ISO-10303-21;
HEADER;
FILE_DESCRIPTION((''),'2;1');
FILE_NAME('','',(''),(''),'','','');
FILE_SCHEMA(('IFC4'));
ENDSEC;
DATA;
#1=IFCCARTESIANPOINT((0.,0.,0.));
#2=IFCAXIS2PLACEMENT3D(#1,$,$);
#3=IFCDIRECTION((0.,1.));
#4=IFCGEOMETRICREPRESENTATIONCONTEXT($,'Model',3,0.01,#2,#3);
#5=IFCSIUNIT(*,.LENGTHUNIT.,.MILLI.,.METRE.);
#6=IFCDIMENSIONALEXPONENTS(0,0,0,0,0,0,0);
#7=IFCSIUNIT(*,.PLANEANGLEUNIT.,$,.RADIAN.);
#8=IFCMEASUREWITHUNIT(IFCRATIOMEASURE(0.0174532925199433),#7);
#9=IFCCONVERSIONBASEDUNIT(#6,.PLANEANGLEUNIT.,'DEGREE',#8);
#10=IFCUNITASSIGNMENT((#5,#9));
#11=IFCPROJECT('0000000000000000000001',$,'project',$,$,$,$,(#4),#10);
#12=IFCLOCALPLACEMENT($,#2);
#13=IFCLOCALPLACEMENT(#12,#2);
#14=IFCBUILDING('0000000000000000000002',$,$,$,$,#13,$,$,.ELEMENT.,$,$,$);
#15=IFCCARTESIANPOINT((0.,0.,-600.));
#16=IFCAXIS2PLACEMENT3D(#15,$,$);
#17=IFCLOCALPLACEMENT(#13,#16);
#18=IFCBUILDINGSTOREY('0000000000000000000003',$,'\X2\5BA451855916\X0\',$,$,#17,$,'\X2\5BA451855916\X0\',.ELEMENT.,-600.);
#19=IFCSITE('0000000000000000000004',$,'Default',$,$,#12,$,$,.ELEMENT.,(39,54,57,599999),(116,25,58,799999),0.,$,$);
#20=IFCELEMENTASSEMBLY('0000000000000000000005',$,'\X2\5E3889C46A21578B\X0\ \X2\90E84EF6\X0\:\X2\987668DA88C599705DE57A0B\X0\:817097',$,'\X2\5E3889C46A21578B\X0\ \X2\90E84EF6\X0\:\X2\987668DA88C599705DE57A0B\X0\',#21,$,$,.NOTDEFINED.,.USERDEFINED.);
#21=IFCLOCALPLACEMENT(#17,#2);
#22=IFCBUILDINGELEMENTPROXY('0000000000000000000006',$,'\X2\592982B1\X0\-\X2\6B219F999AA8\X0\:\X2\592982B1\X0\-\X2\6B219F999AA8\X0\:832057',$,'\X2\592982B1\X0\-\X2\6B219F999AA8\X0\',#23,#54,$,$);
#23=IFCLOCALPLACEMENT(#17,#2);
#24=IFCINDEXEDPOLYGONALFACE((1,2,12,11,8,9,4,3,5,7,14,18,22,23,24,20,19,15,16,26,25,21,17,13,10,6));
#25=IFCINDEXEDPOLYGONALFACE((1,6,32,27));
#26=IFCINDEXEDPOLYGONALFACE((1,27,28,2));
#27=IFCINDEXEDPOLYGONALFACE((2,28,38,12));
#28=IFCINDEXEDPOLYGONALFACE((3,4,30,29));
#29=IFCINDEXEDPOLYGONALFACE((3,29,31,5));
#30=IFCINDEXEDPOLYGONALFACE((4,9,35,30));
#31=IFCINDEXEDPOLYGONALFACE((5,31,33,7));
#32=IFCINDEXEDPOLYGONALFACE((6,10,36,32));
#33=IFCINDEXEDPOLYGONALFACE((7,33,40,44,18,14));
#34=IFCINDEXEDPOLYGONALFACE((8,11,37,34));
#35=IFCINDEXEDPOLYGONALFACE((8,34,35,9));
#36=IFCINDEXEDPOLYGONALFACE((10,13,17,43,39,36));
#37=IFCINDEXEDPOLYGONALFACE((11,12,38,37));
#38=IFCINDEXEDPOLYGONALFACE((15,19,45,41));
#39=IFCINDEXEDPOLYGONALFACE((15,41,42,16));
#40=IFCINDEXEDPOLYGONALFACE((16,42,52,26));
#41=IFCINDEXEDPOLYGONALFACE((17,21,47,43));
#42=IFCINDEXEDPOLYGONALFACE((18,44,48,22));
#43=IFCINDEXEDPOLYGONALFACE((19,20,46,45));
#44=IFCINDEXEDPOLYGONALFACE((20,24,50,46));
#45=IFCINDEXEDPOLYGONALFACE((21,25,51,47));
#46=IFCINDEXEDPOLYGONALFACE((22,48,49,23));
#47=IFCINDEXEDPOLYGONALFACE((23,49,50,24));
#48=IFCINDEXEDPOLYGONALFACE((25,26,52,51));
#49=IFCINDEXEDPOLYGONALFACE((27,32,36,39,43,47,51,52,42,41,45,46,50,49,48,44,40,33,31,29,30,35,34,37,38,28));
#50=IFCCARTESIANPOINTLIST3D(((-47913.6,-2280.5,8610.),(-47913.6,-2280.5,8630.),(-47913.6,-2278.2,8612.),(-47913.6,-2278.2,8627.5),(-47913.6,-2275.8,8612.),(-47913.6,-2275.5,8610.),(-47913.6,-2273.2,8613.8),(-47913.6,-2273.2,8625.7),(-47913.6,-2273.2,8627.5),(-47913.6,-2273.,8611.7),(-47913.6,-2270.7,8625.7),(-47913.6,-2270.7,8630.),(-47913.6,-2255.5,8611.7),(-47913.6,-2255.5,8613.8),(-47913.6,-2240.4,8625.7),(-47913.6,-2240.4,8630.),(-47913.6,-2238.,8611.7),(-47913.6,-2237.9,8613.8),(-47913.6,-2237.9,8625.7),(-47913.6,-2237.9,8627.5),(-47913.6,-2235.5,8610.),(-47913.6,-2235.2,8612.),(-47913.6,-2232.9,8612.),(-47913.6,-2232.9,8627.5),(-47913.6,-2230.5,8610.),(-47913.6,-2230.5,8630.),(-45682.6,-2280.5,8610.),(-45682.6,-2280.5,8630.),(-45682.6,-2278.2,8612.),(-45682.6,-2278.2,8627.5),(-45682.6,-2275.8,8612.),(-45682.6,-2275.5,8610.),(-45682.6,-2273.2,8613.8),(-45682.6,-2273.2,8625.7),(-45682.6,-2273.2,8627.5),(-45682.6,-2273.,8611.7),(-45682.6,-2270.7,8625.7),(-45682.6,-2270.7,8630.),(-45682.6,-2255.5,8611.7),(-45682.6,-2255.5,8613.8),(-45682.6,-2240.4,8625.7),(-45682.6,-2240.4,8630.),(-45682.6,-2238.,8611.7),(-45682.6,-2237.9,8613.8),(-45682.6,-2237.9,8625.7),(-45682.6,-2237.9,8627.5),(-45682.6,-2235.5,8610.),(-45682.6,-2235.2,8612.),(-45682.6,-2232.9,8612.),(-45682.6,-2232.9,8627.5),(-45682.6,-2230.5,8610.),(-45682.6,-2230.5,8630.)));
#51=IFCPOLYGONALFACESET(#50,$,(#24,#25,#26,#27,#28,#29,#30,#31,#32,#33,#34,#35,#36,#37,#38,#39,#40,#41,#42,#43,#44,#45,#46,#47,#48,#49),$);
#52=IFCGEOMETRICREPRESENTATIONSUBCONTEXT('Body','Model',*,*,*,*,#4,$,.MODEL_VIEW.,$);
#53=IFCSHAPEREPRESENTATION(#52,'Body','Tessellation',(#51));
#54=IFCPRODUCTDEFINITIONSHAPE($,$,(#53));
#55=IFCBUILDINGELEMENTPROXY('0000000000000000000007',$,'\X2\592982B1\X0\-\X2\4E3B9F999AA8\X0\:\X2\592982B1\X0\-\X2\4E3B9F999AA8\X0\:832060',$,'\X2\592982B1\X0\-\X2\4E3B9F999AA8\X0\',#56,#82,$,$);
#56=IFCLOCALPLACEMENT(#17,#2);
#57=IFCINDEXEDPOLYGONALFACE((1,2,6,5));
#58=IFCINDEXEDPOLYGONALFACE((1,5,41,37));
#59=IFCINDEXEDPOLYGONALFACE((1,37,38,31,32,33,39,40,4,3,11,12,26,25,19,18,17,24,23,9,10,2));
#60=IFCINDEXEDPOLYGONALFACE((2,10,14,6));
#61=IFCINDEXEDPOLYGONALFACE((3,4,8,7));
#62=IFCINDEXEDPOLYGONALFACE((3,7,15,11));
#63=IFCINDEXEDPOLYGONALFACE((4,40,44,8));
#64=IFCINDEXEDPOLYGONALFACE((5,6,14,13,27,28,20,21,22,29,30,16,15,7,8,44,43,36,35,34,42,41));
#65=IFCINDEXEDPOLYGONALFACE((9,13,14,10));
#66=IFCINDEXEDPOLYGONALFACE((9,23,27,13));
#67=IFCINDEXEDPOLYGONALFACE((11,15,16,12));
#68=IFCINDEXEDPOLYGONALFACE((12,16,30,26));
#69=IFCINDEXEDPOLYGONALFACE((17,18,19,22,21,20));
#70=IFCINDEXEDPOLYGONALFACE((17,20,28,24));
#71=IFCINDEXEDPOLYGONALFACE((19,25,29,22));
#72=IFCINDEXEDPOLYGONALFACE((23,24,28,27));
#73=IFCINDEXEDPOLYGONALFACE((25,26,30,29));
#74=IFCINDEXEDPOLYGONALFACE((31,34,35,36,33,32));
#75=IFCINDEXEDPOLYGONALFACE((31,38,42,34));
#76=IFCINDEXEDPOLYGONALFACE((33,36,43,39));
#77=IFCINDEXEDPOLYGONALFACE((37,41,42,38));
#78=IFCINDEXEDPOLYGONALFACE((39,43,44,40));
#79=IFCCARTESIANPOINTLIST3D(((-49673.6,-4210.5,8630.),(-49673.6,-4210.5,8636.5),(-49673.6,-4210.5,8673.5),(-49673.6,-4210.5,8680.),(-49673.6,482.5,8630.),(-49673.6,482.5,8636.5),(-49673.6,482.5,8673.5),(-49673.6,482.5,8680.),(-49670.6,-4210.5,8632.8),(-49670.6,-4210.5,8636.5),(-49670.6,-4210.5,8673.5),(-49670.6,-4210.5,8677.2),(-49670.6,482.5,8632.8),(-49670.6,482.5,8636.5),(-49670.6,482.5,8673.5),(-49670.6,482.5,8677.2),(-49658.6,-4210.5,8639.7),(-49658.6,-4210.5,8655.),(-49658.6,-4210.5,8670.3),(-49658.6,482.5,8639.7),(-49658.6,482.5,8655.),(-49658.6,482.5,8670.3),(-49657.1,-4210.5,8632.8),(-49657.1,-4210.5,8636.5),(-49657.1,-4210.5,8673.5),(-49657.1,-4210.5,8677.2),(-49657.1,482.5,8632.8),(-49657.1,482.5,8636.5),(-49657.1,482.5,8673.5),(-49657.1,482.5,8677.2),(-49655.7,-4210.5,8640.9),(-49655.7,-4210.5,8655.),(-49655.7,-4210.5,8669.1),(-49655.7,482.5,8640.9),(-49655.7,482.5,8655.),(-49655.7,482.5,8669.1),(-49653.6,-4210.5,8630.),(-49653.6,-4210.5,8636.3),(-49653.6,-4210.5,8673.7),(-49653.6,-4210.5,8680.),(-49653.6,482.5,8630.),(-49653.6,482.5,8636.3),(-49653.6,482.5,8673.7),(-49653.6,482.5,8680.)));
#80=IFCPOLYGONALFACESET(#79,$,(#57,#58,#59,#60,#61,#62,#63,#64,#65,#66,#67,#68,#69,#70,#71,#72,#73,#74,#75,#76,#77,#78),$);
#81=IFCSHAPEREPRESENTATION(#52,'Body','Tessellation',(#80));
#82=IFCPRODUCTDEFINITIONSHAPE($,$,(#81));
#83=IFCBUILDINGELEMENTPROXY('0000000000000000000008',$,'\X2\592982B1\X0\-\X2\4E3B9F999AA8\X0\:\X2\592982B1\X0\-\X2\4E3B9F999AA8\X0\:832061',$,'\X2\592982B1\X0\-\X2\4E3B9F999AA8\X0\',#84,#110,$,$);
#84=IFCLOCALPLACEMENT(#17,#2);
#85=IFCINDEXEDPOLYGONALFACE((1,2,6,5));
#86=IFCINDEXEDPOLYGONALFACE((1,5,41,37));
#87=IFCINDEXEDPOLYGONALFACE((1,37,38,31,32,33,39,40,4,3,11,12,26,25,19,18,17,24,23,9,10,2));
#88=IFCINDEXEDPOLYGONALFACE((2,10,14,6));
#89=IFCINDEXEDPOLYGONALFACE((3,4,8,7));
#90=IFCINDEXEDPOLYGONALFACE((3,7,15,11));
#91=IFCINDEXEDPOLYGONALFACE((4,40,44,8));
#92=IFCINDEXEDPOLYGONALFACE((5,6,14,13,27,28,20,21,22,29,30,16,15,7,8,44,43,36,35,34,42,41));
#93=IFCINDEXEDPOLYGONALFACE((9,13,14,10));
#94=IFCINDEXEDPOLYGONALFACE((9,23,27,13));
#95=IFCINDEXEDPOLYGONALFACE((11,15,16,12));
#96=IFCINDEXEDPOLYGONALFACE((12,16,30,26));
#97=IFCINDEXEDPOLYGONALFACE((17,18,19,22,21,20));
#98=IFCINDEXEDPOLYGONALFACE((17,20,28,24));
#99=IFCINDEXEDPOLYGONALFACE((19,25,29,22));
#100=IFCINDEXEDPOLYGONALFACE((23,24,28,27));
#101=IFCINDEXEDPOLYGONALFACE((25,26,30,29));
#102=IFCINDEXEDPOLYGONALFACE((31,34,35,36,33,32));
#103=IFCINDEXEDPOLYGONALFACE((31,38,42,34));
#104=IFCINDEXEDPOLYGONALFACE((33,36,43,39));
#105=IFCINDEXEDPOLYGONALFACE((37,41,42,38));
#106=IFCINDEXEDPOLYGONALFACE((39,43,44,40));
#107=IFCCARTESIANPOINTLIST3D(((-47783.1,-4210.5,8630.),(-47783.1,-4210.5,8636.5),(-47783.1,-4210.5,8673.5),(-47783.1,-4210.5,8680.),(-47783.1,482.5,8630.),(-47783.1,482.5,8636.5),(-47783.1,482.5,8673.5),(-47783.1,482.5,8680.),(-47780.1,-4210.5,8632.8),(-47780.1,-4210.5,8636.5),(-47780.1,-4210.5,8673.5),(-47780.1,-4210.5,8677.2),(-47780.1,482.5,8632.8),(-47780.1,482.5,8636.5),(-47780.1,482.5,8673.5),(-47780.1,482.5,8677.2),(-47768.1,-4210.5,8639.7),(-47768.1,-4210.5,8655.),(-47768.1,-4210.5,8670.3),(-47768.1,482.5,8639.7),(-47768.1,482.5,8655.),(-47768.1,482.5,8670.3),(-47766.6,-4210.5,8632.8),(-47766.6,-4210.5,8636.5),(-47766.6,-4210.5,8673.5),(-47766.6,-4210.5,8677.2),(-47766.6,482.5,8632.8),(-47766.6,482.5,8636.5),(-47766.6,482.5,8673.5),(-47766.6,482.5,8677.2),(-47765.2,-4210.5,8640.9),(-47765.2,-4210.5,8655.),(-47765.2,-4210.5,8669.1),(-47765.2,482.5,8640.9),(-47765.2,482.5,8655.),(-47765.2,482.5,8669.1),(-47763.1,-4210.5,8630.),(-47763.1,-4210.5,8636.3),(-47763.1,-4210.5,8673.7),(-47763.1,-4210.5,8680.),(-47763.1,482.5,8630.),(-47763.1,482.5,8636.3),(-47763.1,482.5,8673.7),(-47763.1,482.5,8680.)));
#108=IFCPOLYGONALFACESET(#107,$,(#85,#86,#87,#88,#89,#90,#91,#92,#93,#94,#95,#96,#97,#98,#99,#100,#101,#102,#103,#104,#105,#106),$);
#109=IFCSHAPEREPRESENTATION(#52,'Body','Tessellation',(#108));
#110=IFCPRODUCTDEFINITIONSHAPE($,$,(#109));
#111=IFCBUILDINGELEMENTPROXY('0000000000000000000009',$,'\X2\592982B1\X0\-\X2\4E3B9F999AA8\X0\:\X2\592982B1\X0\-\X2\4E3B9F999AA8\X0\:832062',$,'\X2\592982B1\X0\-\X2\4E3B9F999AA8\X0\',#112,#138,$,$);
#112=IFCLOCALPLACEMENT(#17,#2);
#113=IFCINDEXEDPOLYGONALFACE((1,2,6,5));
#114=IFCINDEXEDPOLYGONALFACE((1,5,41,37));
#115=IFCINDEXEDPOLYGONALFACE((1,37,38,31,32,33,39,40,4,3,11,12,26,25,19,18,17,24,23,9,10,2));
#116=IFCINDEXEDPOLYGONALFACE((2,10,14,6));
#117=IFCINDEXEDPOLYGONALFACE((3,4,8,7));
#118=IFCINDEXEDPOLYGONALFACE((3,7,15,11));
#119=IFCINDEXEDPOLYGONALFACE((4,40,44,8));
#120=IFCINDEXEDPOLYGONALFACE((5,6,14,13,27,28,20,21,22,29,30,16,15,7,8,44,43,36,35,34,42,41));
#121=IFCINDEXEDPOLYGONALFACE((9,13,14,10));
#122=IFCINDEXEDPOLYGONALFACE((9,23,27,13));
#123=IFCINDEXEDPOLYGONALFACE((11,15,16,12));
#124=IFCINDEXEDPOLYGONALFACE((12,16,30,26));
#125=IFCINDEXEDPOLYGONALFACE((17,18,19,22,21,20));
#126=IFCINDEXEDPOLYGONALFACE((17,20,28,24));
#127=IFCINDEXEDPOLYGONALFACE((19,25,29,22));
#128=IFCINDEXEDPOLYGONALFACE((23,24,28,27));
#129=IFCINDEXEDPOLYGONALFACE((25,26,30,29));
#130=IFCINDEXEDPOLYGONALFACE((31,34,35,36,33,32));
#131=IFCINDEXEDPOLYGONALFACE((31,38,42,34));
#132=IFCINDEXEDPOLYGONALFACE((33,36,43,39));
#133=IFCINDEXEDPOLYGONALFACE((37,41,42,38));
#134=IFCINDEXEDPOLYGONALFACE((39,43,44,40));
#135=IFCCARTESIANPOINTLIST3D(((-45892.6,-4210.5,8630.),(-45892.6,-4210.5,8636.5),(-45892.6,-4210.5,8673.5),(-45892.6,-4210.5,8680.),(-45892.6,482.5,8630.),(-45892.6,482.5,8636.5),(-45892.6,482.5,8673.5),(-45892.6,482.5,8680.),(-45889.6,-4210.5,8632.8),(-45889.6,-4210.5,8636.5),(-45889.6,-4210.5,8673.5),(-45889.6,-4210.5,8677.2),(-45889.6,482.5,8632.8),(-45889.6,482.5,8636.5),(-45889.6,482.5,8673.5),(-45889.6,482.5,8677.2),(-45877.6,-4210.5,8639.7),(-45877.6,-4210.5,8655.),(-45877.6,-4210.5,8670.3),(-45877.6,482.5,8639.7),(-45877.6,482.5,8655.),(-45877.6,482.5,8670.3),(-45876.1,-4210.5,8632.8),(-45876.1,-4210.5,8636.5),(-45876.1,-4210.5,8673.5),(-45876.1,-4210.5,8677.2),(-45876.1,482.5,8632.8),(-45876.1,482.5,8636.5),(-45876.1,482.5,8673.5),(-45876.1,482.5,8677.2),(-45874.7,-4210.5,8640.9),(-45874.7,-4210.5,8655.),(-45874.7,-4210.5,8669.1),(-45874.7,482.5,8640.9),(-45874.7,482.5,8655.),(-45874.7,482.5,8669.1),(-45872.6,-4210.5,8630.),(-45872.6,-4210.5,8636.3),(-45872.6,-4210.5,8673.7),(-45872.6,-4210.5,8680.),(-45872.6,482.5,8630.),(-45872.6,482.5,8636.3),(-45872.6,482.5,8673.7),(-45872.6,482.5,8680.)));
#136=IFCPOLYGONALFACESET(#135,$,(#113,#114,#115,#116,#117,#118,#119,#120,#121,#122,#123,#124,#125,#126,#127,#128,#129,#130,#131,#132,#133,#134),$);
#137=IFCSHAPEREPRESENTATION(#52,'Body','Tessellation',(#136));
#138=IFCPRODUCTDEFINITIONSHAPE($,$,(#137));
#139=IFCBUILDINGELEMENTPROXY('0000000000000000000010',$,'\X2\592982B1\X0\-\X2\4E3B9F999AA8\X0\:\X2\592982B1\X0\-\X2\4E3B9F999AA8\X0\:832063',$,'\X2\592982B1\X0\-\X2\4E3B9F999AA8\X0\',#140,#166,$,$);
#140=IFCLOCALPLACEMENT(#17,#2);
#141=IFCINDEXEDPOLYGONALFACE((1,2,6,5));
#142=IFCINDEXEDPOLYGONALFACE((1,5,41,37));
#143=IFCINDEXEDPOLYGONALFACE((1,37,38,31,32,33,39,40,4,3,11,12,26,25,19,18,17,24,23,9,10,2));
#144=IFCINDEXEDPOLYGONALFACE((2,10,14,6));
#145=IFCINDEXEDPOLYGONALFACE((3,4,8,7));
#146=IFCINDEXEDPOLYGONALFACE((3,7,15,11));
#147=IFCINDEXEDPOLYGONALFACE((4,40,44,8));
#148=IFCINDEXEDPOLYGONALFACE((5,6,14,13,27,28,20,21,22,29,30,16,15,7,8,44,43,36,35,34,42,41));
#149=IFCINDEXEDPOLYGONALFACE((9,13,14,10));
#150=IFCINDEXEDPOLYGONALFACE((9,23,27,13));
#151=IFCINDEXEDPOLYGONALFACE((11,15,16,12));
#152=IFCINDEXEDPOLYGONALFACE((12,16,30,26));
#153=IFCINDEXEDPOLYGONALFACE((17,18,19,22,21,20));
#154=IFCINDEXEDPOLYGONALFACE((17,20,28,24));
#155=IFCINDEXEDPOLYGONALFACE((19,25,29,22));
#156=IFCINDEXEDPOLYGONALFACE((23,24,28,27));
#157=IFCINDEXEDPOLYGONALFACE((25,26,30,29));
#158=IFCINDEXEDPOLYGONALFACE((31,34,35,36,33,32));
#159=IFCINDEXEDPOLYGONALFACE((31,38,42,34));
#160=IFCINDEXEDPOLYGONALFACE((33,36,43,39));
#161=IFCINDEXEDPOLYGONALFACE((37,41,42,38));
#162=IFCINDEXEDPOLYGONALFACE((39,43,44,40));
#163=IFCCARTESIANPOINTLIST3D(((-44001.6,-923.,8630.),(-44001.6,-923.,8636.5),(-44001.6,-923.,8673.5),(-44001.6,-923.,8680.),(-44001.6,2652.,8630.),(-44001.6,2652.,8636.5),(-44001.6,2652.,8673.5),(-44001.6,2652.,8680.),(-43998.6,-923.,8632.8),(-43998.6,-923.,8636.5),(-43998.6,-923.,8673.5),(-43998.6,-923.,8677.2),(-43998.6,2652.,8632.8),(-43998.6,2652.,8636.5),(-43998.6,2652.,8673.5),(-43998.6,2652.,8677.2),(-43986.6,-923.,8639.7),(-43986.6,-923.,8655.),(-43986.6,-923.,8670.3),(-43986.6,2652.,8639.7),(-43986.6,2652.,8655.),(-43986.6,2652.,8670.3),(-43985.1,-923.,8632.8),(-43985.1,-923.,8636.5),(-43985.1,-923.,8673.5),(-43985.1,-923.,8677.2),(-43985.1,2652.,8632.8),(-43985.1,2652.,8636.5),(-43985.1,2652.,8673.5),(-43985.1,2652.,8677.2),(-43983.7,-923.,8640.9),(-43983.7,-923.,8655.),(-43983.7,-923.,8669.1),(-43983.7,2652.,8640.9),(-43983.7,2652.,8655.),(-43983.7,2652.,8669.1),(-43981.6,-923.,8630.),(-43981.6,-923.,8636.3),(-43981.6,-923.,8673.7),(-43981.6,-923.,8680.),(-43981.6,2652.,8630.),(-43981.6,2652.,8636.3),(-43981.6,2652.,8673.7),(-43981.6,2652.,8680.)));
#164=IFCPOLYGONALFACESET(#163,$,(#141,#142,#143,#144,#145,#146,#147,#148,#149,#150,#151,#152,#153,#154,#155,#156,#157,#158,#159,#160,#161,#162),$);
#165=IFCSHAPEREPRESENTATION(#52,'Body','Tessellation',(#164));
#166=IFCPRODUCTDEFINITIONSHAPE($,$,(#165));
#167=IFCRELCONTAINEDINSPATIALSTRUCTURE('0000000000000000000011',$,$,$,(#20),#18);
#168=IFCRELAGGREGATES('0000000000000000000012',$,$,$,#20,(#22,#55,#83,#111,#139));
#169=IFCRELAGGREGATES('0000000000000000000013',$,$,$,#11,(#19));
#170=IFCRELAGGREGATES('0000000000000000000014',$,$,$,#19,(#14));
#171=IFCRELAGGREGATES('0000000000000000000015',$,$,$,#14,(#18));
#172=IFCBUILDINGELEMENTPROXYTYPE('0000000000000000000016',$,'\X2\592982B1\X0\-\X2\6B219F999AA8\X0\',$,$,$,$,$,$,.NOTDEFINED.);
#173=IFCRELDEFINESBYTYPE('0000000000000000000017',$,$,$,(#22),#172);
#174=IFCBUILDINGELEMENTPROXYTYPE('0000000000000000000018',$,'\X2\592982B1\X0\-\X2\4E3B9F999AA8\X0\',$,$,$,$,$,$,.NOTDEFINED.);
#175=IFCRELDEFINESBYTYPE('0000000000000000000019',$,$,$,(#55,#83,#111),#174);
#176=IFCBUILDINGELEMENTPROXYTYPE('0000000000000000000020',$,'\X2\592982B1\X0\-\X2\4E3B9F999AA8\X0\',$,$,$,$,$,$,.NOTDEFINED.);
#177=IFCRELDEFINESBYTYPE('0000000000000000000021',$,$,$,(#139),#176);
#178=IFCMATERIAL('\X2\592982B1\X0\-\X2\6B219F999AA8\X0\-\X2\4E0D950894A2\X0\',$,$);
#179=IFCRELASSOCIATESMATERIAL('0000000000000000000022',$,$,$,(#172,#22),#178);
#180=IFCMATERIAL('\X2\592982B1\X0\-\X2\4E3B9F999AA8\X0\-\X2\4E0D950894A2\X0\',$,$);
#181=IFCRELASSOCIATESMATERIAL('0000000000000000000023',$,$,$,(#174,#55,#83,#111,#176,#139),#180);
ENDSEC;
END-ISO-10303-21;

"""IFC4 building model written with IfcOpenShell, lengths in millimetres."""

from ifc_helpers import new_model, entity, si_unit, converted_unit, direction, frame, origin, place, context, subcontext, project, spatial, polyline, outline, extrude, source, transform, mapped, material, type_object, type_shapes, element, aggregate, save


model = new_model("IFC4")

# Units and contexts
model_context = context("Model", 3, precision=0.01, world=origin(), true_north=direction((0.0, 1.0)))
body_context = subcontext(model_context, "Body", "Model", "MODEL_VIEW")
ifc_project = project(units=[si_unit("LENGTHUNIT", "METRE", prefix="MILLI"), converted_unit("PLANEANGLEUNIT", "DEGREE", entity("IfcRatioMeasure", 0.0174532925199433), si_unit("PLANEANGLEUNIT", "RADIAN"), dimensions=[0, 0, 0, 0, 0, 0, 0])], contexts=[model_context])

# Site, building, storey
site_placement = place(None, origin())
site = spatial("IfcSite", under=ifc_project, at=site_placement, Name="Default", CompositionType="ELEMENT", RefLatitude=(39, 54, 57, 599999), RefLongitude=(116, 25, 58, 799999), RefElevation=0.0)
building_placement = place(site_placement, origin())
building = spatial("IfcBuilding", under=site, at=building_placement, CompositionType="ELEMENT")
storey_placement = place(building_placement, frame((0.0, 0.0, -600.0)))
storey = spatial("IfcBuildingStorey", under=building, at=storey_placement, Name="室内外", LongName="室内外", CompositionType="ELEMENT", Elevation=-600.0)

# Element assembly, building element proxies
assembly_1_placement = place(storey_placement, origin())
assembly_1 = element("IfcElementAssembly", 1, at=assembly_1_placement, inside=storey, Name="常规模型 部件:顶棚装饰工程:817097", ObjectType="常规模型 部件:顶棚装饰工程", AssemblyPlace="NOTDEFINED", PredefinedType="USERDEFINED")
ifc_material_1 = material(Name="天花-次龙骨-不锈钢")
building_element_proxy_type_1 = type_object("IfcBuildingElementProxyType", Name="天花-次龙骨", PredefinedType="NOTDEFINED", material=ifc_material_1)
shared_shape_1 = source(origin(), body_context, "Body", "SweptSolid", [
    extrude(outline(polyline([(-25.0, -9.1), (-20.0, -9.1), (-17.5, -7.4), (0.0, -7.4), (17.5, -7.4), (20.0, -9.1), (25.0, -9.1), (25.0, 10.9), (15.1, 10.9), (15.1, 6.6), (17.6, 6.6), (17.6, 8.4), (22.6, 8.4), (22.6, -7.1), (20.3, -7.1), (17.6, -5.3), (0.0, -5.3), (-17.6, -5.3), (-20.3, -7.1), (-22.6, -7.1), (-22.6, 8.4), (-17.6, 8.4), (-17.6, 6.6), (-15.1, 6.6), (-15.1, 10.9), (-25.0, 10.9), (-25.0, -9.1)])), frame((0.0, 0.0, -0.9), z_axis=(1.0, 0.0, 0.0), x_axis=(0.0, 1.0, 0.0)), (0.0, 0.0, 1.0), 2231.0),
])
type_shapes(building_element_proxy_type_1, [shared_shape_1])
proxy_1_placement = place(assembly_1_placement, frame((-47913.6, -2255.5, 8620.0)))
proxy_1 = element("IfcBuildingElementProxy", 2, at=proxy_1_placement, type_object=building_element_proxy_type_1, material=ifc_material_1, Name="天花-次龙骨:天花-次龙骨:832057", ObjectType="天花-次龙骨", context=body_context, shape_type="MappedRepresentation", body=[
    mapped(shared_shape_1, transform((0.0, 0.0, 0.0), scale=1.0)),
])
ifc_material_2 = material(Name="天花-主龙骨-不锈钢")
building_element_proxy_type_2 = type_object("IfcBuildingElementProxyType", Name="天花-主龙骨", PredefinedType="NOTDEFINED", material=ifc_material_2)
shared_shape_2 = source(origin(), body_context, "Body", "SweptSolid", [
    extrude(outline(polyline([(-25.0, -11.7), (-18.5, -11.7), (-18.5, -8.7), (-22.2, -8.7), (-22.2, 4.8), (-18.5, 4.8), (-15.3, 3.3), (0.0, 3.3), (15.3, 3.3), (18.5, 4.8), (22.2, 4.8), (22.2, -8.7), (18.5, -8.7), (18.5, -11.7), (25.0, -11.7), (25.0, 8.3), (18.7, 8.3), (14.1, 6.2), (0.0, 6.2), (-14.1, 6.2), (-18.7, 8.3), (-25.0, 8.3), (-25.0, -11.7)])), frame((0.0, 1.7, 0.0), z_axis=(1.0, 0.0, 0.0), x_axis=(0.0, 0.0, -1.0)), (0.0, 0.0, 1.0), 4693.0),
])
type_shapes(building_element_proxy_type_2, [shared_shape_2])
proxy_2_placement = place(assembly_1_placement, frame((-49663.6, 482.5, 8655.0), z_axis=(0.0, 0.0, 1.0), x_axis=(0.0, -1.0, 0.0)))
proxy_2 = element("IfcBuildingElementProxy", 3, at=proxy_2_placement, type_object=building_element_proxy_type_2, material=ifc_material_2, Name="天花-主龙骨:天花-主龙骨:832060", ObjectType="天花-主龙骨", context=body_context, shape_type="MappedRepresentation", body=[
    mapped(shared_shape_2, transform((0.0, 0.0, 0.0), scale=1.0)),
])
proxy_3_placement = place(assembly_1_placement, frame((-47773.1, 482.5, 8655.0), z_axis=(0.0, 0.0, 1.0), x_axis=(0.0, -1.0, 0.0)))
proxy_3 = element("IfcBuildingElementProxy", 4, at=proxy_3_placement, type_object=building_element_proxy_type_2, material=ifc_material_2, Name="天花-主龙骨:天花-主龙骨:832061", ObjectType="天花-主龙骨", context=body_context, shape_type="MappedRepresentation", body=[
    mapped(shared_shape_2, transform((0.0, 0.0, 0.0), scale=1.0)),
])
proxy_4_placement = place(assembly_1_placement, frame((-45882.6, 482.5, 8655.0), z_axis=(0.0, 0.0, 1.0), x_axis=(0.0, -1.0, 0.0)))
proxy_4 = element("IfcBuildingElementProxy", 5, at=proxy_4_placement, type_object=building_element_proxy_type_2, material=ifc_material_2, Name="天花-主龙骨:天花-主龙骨:832062", ObjectType="天花-主龙骨", context=body_context, shape_type="MappedRepresentation", body=[
    mapped(shared_shape_2, transform((0.0, 0.0, 0.0), scale=1.0)),
])
building_element_proxy_type_3 = type_object("IfcBuildingElementProxyType", Name="天花-主龙骨", PredefinedType="NOTDEFINED", material=ifc_material_2)
shared_shape_3 = source(origin(), body_context, "Body", "SweptSolid", [
    extrude(outline(polyline([(-25.0, -11.7), (-18.5, -11.7), (-18.5, -8.7), (-22.2, -8.7), (-22.2, 4.8), (-18.5, 4.8), (-15.3, 3.3), (0.0, 3.3), (15.3, 3.3), (18.5, 4.8), (22.2, 4.8), (22.2, -8.7), (18.5, -8.7), (18.5, -11.7), (25.0, -11.7), (25.0, 8.3), (18.7, 8.3), (14.1, 6.2), (0.0, 6.2), (-14.1, 6.2), (-18.7, 8.3), (-25.0, 8.3), (-25.0, -11.7)])), frame((0.0, 1.7, 0.0), z_axis=(1.0, 0.0, 0.0), x_axis=(0.0, 0.0, -1.0)), (0.0, 0.0, 1.0), 3575.0),
])
type_shapes(building_element_proxy_type_3, [shared_shape_3])
proxy_5_placement = place(assembly_1_placement, frame((-43991.6, 2652.0, 8655.0), z_axis=(0.0, 0.0, 1.0), x_axis=(0.0, -1.0, 0.0)))
proxy_5 = element("IfcBuildingElementProxy", 6, at=proxy_5_placement, type_object=building_element_proxy_type_3, material=ifc_material_2, Name="天花-主龙骨:天花-主龙骨:832063", ObjectType="天花-主龙骨", context=body_context, shape_type="MappedRepresentation", body=[
    mapped(shared_shape_3, transform((0.0, 0.0, 0.0), scale=1.0)),
])
aggregate(assembly_1, [proxy_1, proxy_2, proxy_3, proxy_4, proxy_5])

save(model, "model.ifc")
